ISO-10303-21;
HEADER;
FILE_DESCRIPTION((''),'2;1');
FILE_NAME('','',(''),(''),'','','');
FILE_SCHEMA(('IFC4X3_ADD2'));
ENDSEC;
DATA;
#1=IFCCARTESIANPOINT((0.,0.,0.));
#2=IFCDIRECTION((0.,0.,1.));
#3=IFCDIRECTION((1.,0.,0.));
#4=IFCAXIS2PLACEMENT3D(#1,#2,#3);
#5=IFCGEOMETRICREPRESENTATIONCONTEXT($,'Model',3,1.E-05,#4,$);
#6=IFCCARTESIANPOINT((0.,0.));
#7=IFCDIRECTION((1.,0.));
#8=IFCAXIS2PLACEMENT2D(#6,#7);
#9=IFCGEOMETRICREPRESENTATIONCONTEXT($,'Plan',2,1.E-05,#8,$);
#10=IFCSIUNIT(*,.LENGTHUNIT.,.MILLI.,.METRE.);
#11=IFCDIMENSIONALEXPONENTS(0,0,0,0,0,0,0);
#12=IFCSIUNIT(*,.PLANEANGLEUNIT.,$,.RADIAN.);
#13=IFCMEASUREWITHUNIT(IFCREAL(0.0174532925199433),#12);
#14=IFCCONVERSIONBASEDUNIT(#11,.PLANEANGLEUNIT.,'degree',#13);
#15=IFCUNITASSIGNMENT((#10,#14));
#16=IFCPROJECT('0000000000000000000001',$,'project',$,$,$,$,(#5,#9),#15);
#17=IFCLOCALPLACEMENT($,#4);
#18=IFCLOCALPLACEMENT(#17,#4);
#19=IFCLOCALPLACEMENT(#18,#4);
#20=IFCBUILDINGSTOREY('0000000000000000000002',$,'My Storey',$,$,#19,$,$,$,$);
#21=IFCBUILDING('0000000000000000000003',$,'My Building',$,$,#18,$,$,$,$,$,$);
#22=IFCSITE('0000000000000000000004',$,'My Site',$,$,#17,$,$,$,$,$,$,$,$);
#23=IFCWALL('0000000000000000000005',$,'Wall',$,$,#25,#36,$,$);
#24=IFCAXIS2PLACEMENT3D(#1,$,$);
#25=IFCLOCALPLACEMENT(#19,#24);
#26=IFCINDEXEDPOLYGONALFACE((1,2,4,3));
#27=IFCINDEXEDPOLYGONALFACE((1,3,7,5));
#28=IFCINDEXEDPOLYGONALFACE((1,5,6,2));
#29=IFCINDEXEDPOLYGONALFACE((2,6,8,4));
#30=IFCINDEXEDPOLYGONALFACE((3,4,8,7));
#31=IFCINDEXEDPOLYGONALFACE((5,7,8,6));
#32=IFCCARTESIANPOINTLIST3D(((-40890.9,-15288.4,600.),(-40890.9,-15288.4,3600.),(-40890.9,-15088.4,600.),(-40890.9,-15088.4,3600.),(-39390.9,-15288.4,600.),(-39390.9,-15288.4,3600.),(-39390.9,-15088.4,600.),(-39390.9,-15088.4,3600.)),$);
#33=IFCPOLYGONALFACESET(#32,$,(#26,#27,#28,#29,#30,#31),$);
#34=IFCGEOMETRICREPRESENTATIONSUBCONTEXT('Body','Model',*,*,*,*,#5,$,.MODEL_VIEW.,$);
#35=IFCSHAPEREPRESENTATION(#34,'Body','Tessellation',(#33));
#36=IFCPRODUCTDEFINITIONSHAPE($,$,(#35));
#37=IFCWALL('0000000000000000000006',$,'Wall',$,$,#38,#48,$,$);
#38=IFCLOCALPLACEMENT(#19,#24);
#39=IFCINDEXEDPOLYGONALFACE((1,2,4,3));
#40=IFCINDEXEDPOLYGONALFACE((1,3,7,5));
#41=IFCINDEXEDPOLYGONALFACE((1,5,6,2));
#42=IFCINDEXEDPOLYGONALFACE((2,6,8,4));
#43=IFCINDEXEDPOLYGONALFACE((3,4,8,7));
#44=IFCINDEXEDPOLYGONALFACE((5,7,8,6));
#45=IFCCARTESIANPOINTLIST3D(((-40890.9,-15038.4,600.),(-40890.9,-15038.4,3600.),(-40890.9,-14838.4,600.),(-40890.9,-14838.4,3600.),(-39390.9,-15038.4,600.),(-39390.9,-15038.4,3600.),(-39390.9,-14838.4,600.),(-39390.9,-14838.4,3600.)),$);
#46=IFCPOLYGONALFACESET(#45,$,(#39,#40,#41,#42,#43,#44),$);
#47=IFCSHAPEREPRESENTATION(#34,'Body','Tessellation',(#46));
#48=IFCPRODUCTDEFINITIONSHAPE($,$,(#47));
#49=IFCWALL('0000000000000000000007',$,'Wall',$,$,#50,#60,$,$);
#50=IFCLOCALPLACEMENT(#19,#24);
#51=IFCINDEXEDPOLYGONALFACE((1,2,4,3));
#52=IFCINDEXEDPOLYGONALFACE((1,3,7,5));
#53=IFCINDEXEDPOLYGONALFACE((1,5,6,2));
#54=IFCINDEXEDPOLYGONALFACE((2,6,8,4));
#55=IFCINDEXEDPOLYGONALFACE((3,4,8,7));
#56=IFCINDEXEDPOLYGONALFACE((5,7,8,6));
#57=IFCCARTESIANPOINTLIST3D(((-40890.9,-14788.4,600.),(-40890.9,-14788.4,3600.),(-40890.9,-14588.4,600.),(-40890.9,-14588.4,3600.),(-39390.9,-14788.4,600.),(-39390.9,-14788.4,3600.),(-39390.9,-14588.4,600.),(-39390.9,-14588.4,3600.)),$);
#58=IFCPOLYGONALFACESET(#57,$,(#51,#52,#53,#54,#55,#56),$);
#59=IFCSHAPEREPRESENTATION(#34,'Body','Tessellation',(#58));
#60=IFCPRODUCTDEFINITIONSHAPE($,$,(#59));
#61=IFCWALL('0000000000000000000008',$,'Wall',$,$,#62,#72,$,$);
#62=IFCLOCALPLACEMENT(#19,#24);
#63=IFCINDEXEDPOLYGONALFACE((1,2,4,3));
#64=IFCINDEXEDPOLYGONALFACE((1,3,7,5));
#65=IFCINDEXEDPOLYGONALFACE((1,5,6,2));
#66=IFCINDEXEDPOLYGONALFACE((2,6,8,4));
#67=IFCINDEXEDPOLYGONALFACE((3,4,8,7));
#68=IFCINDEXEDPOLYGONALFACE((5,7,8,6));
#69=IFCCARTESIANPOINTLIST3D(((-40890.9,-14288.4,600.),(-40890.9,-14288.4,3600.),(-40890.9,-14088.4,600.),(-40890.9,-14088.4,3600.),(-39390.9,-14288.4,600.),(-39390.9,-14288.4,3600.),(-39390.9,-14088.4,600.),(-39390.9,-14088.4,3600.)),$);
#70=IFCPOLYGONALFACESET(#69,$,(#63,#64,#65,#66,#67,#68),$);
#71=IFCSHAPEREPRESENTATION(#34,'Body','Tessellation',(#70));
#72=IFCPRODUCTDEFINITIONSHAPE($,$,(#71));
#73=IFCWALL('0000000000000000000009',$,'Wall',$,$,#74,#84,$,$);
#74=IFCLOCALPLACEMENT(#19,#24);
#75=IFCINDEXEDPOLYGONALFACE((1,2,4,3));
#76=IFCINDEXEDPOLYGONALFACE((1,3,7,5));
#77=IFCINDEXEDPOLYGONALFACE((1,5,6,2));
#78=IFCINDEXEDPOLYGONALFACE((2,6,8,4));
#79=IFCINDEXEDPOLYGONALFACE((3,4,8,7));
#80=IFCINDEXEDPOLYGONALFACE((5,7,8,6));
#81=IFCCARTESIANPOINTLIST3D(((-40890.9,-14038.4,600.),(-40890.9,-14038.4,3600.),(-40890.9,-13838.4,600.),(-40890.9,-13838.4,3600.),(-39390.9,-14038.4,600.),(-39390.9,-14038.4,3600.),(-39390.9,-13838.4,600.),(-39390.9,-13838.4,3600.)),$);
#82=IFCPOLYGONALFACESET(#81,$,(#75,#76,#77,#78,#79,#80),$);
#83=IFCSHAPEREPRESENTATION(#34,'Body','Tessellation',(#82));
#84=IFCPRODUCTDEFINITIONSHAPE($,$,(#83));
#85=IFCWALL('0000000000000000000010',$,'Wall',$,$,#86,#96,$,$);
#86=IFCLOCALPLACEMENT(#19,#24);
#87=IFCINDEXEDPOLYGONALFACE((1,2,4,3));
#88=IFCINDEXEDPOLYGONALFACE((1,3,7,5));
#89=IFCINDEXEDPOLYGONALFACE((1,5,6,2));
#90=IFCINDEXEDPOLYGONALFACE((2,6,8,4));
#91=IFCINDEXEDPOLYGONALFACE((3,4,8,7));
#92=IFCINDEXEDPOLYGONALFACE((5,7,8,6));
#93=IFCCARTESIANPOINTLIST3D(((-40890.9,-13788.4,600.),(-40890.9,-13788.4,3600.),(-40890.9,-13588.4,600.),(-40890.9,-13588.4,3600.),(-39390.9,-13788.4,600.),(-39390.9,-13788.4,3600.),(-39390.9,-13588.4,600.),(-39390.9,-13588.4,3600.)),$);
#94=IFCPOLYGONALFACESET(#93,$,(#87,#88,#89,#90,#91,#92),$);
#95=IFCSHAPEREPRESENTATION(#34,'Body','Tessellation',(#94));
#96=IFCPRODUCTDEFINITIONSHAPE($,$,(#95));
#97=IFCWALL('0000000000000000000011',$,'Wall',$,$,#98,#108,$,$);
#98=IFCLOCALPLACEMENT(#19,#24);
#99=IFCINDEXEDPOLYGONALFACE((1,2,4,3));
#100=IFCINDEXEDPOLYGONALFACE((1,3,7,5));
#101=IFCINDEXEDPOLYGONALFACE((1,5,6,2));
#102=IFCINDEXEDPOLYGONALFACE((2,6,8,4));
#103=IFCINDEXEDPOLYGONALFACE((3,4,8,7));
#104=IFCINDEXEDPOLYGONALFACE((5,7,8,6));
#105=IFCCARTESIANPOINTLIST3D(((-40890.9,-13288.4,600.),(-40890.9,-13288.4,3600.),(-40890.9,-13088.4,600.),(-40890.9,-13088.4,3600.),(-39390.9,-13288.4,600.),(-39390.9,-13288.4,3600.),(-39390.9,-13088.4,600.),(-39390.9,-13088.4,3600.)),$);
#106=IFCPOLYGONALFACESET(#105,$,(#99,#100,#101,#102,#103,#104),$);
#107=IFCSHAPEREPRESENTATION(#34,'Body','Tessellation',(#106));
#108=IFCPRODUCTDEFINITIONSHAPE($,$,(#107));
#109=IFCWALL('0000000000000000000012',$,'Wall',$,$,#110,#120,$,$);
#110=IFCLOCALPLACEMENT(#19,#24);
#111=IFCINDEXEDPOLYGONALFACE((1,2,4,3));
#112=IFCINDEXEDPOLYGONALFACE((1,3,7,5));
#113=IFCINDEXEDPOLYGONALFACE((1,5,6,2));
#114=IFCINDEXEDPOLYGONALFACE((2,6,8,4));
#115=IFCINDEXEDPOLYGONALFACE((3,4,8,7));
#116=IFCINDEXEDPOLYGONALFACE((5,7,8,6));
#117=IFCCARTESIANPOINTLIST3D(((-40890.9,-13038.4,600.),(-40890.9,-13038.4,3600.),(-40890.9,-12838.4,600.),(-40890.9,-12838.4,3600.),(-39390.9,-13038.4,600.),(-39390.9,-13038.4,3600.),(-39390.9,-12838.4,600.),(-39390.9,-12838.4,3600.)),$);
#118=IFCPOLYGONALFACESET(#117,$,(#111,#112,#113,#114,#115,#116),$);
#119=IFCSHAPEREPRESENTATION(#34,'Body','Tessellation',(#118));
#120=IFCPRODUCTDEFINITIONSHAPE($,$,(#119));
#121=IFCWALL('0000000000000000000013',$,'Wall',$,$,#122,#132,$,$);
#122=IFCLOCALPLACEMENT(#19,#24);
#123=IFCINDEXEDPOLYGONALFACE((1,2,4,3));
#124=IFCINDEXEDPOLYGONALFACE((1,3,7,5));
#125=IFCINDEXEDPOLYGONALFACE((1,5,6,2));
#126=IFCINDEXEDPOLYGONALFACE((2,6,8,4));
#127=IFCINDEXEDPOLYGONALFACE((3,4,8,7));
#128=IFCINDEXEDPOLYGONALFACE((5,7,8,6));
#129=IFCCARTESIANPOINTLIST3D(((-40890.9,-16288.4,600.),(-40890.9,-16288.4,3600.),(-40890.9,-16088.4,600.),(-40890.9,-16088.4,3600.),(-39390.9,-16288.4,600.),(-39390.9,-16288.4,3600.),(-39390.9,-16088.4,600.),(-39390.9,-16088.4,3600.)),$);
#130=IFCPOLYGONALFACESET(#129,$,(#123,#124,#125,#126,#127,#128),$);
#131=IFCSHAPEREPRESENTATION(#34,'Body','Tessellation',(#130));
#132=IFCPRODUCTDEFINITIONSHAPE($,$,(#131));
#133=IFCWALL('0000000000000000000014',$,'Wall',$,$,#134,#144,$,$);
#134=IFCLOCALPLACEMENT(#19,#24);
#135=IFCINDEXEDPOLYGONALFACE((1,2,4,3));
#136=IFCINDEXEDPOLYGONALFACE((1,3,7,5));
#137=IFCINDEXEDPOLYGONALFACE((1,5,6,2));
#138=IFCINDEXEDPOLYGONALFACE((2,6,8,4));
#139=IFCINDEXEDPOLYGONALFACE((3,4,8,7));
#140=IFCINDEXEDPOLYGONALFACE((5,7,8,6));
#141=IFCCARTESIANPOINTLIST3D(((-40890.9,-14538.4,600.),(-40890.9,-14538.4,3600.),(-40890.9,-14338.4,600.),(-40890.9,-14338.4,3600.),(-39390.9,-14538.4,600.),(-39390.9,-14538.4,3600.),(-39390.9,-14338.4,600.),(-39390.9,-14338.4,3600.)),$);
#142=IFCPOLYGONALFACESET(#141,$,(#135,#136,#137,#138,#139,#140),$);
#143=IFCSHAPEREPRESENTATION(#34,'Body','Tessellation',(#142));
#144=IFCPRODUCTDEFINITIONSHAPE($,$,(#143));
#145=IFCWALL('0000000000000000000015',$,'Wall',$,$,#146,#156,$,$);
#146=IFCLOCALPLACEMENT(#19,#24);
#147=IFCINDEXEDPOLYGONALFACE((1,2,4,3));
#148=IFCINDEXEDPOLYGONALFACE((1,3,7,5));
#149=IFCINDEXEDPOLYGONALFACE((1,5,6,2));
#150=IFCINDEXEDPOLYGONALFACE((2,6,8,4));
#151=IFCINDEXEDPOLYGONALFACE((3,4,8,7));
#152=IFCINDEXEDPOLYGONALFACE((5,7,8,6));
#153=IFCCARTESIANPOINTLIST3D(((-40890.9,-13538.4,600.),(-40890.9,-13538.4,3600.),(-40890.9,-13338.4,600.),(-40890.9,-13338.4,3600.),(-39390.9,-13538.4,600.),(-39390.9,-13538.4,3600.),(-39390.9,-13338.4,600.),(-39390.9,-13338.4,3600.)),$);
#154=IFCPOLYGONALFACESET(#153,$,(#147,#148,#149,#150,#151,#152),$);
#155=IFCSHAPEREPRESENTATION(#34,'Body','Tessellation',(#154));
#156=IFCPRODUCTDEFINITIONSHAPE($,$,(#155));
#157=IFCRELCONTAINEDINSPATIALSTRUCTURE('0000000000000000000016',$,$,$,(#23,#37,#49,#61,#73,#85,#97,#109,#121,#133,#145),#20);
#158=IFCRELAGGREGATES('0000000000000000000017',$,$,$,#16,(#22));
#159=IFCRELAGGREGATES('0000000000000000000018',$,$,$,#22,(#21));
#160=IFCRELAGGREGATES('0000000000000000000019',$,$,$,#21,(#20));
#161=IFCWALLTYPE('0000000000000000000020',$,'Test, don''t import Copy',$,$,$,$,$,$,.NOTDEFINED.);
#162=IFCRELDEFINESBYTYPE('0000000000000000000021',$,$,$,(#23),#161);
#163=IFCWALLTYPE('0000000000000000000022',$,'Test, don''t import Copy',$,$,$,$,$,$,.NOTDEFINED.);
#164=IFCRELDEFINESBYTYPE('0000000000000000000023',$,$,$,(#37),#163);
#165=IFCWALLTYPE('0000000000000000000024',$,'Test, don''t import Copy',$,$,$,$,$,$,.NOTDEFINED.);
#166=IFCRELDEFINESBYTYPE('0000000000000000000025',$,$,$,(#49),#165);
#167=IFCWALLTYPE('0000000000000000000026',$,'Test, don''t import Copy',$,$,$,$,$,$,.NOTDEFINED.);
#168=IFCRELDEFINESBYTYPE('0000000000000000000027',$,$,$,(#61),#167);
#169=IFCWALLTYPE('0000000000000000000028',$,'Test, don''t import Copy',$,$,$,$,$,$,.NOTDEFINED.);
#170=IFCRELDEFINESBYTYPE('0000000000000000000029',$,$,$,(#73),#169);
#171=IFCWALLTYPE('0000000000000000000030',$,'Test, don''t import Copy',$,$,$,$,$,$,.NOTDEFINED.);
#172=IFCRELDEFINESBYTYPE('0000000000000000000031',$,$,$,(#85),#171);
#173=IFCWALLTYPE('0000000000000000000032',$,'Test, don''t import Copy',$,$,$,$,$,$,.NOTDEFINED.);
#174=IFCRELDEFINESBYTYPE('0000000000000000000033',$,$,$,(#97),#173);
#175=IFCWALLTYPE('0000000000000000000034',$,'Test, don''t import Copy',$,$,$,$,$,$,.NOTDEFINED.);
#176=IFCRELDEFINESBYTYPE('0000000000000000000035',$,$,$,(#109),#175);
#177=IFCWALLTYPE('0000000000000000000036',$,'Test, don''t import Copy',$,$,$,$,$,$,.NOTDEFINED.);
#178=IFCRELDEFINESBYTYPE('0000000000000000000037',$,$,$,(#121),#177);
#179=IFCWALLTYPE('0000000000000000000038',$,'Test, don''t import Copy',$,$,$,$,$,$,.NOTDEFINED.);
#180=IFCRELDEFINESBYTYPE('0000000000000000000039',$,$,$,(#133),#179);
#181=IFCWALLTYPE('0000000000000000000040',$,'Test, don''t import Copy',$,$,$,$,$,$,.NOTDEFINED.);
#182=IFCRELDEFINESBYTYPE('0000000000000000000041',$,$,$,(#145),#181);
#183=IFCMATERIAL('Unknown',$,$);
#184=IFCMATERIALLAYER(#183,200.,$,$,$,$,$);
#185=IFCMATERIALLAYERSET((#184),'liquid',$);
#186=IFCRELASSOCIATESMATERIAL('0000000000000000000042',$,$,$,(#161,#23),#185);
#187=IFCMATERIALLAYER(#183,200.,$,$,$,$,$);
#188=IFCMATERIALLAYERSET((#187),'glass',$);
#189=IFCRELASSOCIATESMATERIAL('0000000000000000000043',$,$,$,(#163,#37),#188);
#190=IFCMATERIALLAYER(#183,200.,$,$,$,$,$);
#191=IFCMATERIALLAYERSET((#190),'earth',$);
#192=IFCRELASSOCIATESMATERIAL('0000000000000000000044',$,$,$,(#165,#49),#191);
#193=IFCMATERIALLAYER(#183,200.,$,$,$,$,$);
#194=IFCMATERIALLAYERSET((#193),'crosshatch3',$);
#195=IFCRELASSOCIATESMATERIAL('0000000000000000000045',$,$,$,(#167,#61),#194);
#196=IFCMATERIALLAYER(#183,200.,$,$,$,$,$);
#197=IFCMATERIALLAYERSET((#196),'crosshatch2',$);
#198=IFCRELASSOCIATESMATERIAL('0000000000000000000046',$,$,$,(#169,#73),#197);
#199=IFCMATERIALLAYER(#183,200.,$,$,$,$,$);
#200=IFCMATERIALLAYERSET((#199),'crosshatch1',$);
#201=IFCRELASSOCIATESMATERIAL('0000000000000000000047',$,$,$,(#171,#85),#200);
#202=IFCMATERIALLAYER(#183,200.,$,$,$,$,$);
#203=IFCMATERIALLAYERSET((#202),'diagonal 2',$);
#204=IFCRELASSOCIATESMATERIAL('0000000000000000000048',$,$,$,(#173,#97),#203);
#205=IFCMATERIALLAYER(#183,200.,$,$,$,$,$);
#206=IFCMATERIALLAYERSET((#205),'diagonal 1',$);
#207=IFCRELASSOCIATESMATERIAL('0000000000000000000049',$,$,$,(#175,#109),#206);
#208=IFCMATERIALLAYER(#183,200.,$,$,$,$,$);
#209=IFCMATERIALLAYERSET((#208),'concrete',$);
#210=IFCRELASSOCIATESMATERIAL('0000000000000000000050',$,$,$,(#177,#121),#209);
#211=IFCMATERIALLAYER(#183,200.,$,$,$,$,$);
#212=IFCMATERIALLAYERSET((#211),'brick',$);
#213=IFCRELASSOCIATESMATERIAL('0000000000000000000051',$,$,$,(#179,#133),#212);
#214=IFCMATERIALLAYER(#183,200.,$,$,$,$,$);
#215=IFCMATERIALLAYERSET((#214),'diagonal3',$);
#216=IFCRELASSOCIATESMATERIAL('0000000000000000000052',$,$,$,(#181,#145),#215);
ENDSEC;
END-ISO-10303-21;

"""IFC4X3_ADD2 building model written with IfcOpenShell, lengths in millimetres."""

from ifc_helpers import new_model, entity, si_unit, converted_unit, frame, origin_with_axes, origin_2d_with_axis, place, context, subcontext, project, spatial, indexed_curve, outline, extrude, material, layer, layer_set, layer_usage, type_object, element, save


model = new_model("IFC4X3_ADD2")

# Units and contexts
model_context = context("Model", 3, precision=1e-05, world=origin_with_axes())
plan_context = context("Plan", 2, precision=1e-05, world=origin_2d_with_axis())
body_context = subcontext(model_context, "Body", "Model", "MODEL_VIEW")
ifc_project = project(units=[si_unit("LENGTHUNIT", "METRE", prefix="MILLI"), converted_unit("PLANEANGLEUNIT", "degree", entity("IfcReal", 0.0174532925199433), si_unit("PLANEANGLEUNIT", "RADIAN"), dimensions=[0, 0, 0, 0, 0, 0, 0])], contexts=[model_context, plan_context])

# Site, building, storey
site_placement = place(None, origin_with_axes())
site = spatial("IfcSite", under=ifc_project, at=site_placement, Name="My Site")
building_placement = place(site_placement, origin_with_axes())
building = spatial("IfcBuilding", under=site, at=building_placement, Name="My Building")
storey_placement = place(building_placement, origin_with_axes())
storey = spatial("IfcBuildingStorey", under=building, at=storey_placement, Name="My Storey")

# Walls
ifc_material_1 = material(Name="Unknown")
ifc_layer_1 = layer(ifc_material_1, 200.0)
ifc_layer_set_1 = layer_set([ifc_layer_1], Name="liquid")
ifc_layer_usage_1 = layer_usage(ifc_layer_set_1, "AXIS2", "POSITIVE", 0.0)
wall_type_1 = type_object("IfcWallType", Name="Test, don't import Copy", PredefinedType="NOTDEFINED", material=ifc_layer_set_1)
wall_1_placement = place(storey_placement, frame((-40890.9, -15288.4, 600.0), z_axis=(0.0, 0.0, 1.0), x_axis=(1.0, 0.0, 0.0)))
element("IfcWall", 1, at=wall_1_placement, inside=storey, type_object=wall_type_1, material=ifc_layer_usage_1, Name="Wall", context=body_context, shape_type="SweptSolid", body=[
    extrude(outline(indexed_curve([(0.0, 0.0), (0.0, 200.0), (1500.0, 200.0), (1500.0, 0.0), (0.0, 0.0)], self_intersect=False)), origin_with_axes(), (0.0, 0.0, 1.0), 3000.0),
])
ifc_layer_2 = layer(ifc_material_1, 200.0)
ifc_layer_set_2 = layer_set([ifc_layer_2], Name="glass")
ifc_layer_usage_2 = layer_usage(ifc_layer_set_2, "AXIS2", "POSITIVE", 0.0)
wall_type_2 = type_object("IfcWallType", Name="Test, don't import Copy", PredefinedType="NOTDEFINED", material=ifc_layer_set_2)
wall_2_placement = place(storey_placement, frame((-40890.9, -15038.4, 600.0), z_axis=(0.0, 0.0, 1.0), x_axis=(1.0, 0.0, 0.0)))
element("IfcWall", 2, at=wall_2_placement, inside=storey, type_object=wall_type_2, material=ifc_layer_usage_2, Name="Wall", context=body_context, shape_type="SweptSolid", body=[
    extrude(outline(indexed_curve([(0.0, 0.0), (0.0, 200.0), (1500.0, 200.0), (1500.0, 0.0), (0.0, 0.0)], self_intersect=False)), origin_with_axes(), (0.0, 0.0, 1.0), 3000.0),
])
ifc_layer_3 = layer(ifc_material_1, 200.0)
ifc_layer_set_3 = layer_set([ifc_layer_3], Name="earth")
ifc_layer_usage_3 = layer_usage(ifc_layer_set_3, "AXIS2", "POSITIVE", 0.0)
wall_type_3 = type_object("IfcWallType", Name="Test, don't import Copy", PredefinedType="NOTDEFINED", material=ifc_layer_set_3)
wall_3_placement = place(storey_placement, frame((-40890.9, -14788.4, 600.0), z_axis=(0.0, 0.0, 1.0), x_axis=(1.0, 0.0, 0.0)))
element("IfcWall", 3, at=wall_3_placement, inside=storey, type_object=wall_type_3, material=ifc_layer_usage_3, Name="Wall", context=body_context, shape_type="SweptSolid", body=[
    extrude(outline(indexed_curve([(0.0, 0.0), (0.0, 200.0), (1500.0, 200.0), (1500.0, 0.0), (0.0, 0.0)], self_intersect=False)), origin_with_axes(), (0.0, 0.0, 1.0), 3000.0),
])
ifc_layer_4 = layer(ifc_material_1, 200.0)
ifc_layer_set_4 = layer_set([ifc_layer_4], Name="crosshatch3")
ifc_layer_usage_4 = layer_usage(ifc_layer_set_4, "AXIS2", "POSITIVE", 0.0)
wall_type_4 = type_object("IfcWallType", Name="Test, don't import Copy", PredefinedType="NOTDEFINED", material=ifc_layer_set_4)
wall_4_placement = place(storey_placement, frame((-40890.9, -14288.4, 600.0), z_axis=(0.0, 0.0, 1.0), x_axis=(1.0, 0.0, 0.0)))
element("IfcWall", 4, at=wall_4_placement, inside=storey, type_object=wall_type_4, material=ifc_layer_usage_4, Name="Wall", context=body_context, shape_type="SweptSolid", body=[
    extrude(outline(indexed_curve([(0.0, 0.0), (0.0, 200.0), (1500.0, 200.0), (1500.0, 0.0), (0.0, 0.0)], self_intersect=False)), origin_with_axes(), (0.0, 0.0, 1.0), 3000.0),
])
ifc_layer_5 = layer(ifc_material_1, 200.0)
ifc_layer_set_5 = layer_set([ifc_layer_5], Name="crosshatch2")
ifc_layer_usage_5 = layer_usage(ifc_layer_set_5, "AXIS2", "POSITIVE", 0.0)
wall_type_5 = type_object("IfcWallType", Name="Test, don't import Copy", PredefinedType="NOTDEFINED", material=ifc_layer_set_5)
wall_5_placement = place(storey_placement, frame((-40890.9, -14038.4, 600.0), z_axis=(0.0, 0.0, 1.0), x_axis=(1.0, 0.0, 0.0)))
element("IfcWall", 5, at=wall_5_placement, inside=storey, type_object=wall_type_5, material=ifc_layer_usage_5, Name="Wall", context=body_context, shape_type="SweptSolid", body=[
    extrude(outline(indexed_curve([(0.0, 0.0), (0.0, 200.0), (1500.0, 200.0), (1500.0, 0.0), (0.0, 0.0)], self_intersect=False)), origin_with_axes(), (0.0, 0.0, 1.0), 3000.0),
])
ifc_layer_6 = layer(ifc_material_1, 200.0)
ifc_layer_set_6 = layer_set([ifc_layer_6], Name="crosshatch1")
ifc_layer_usage_6 = layer_usage(ifc_layer_set_6, "AXIS2", "POSITIVE", 0.0)
wall_type_6 = type_object("IfcWallType", Name="Test, don't import Copy", PredefinedType="NOTDEFINED", material=ifc_layer_set_6)
wall_6_placement = place(storey_placement, frame((-40890.9, -13788.4, 600.0), z_axis=(0.0, 0.0, 1.0), x_axis=(1.0, 0.0, 0.0)))
element("IfcWall", 6, at=wall_6_placement, inside=storey, type_object=wall_type_6, material=ifc_layer_usage_6, Name="Wall", context=body_context, shape_type="SweptSolid", body=[
    extrude(outline(indexed_curve([(0.0, 0.0), (0.0, 200.0), (1500.0, 200.0), (1500.0, 0.0), (0.0, 0.0)], self_intersect=False)), origin_with_axes(), (0.0, 0.0, 1.0), 3000.0),
])
ifc_layer_7 = layer(ifc_material_1, 200.0)
ifc_layer_set_7 = layer_set([ifc_layer_7], Name="diagonal 2")
ifc_layer_usage_7 = layer_usage(ifc_layer_set_7, "AXIS2", "POSITIVE", 0.0)
wall_type_7 = type_object("IfcWallType", Name="Test, don't import Copy", PredefinedType="NOTDEFINED", material=ifc_layer_set_7)
wall_7_placement = place(storey_placement, frame((-40890.9, -13288.4, 600.0), z_axis=(0.0, 0.0, 1.0), x_axis=(1.0, 0.0, 0.0)))
element("IfcWall", 7, at=wall_7_placement, inside=storey, type_object=wall_type_7, material=ifc_layer_usage_7, Name="Wall", context=body_context, shape_type="SweptSolid", body=[
    extrude(outline(indexed_curve([(0.0, 0.0), (0.0, 200.0), (1500.0, 200.0), (1500.0, 0.0), (0.0, 0.0)], self_intersect=False)), origin_with_axes(), (0.0, 0.0, 1.0), 3000.0),
])
ifc_layer_8 = layer(ifc_material_1, 200.0)
ifc_layer_set_8 = layer_set([ifc_layer_8], Name="diagonal 1")
ifc_layer_usage_8 = layer_usage(ifc_layer_set_8, "AXIS2", "POSITIVE", 0.0)
wall_type_8 = type_object("IfcWallType", Name="Test, don't import Copy", PredefinedType="NOTDEFINED", material=ifc_layer_set_8)
wall_8_placement = place(storey_placement, frame((-40890.9, -13038.4, 600.0), z_axis=(0.0, 0.0, 1.0), x_axis=(1.0, 0.0, 0.0)))
element("IfcWall", 8, at=wall_8_placement, inside=storey, type_object=wall_type_8, material=ifc_layer_usage_8, Name="Wall", context=body_context, shape_type="SweptSolid", body=[
    extrude(outline(indexed_curve([(0.0, 0.0), (0.0, 200.0), (1500.0, 200.0), (1500.0, 0.0), (0.0, 0.0)], self_intersect=False)), origin_with_axes(), (0.0, 0.0, 1.0), 3000.0),
])
ifc_layer_9 = layer(ifc_material_1, 200.0)
ifc_layer_set_9 = layer_set([ifc_layer_9], Name="concrete")
ifc_layer_usage_9 = layer_usage(ifc_layer_set_9, "AXIS2", "POSITIVE", 0.0)
wall_type_9 = type_object("IfcWallType", Name="Test, don't import Copy", PredefinedType="NOTDEFINED", material=ifc_layer_set_9)
wall_9_placement = place(storey_placement, frame((-40890.9, -16288.4, 600.0), z_axis=(0.0, 0.0, 1.0), x_axis=(1.0, 0.0, 0.0)))
element("IfcWall", 9, at=wall_9_placement, inside=storey, type_object=wall_type_9, material=ifc_layer_usage_9, Name="Wall", context=body_context, shape_type="SweptSolid", body=[
    extrude(outline(indexed_curve([(0.0, 0.0), (0.0, 200.0), (1500.0, 200.0), (1500.0, 0.0), (0.0, 0.0)], self_intersect=False)), origin_with_axes(), (0.0, 0.0, 1.0), 3000.0),
])
ifc_layer_10 = layer(ifc_material_1, 200.0)
ifc_layer_set_10 = layer_set([ifc_layer_10], Name="brick")
ifc_layer_usage_10 = layer_usage(ifc_layer_set_10, "AXIS2", "POSITIVE", 0.0)
wall_type_10 = type_object("IfcWallType", Name="Test, don't import Copy", PredefinedType="NOTDEFINED", material=ifc_layer_set_10)
wall_10_placement = place(storey_placement, frame((-40890.9, -14538.4, 600.0), z_axis=(0.0, 0.0, 1.0), x_axis=(1.0, 0.0, 0.0)))
element("IfcWall", 10, at=wall_10_placement, inside=storey, type_object=wall_type_10, material=ifc_layer_usage_10, Name="Wall", context=body_context, shape_type="SweptSolid", body=[
    extrude(outline(indexed_curve([(0.0, 0.0), (0.0, 200.0), (1500.0, 200.0), (1500.0, 0.0), (0.0, 0.0)], self_intersect=False)), origin_with_axes(), (0.0, 0.0, 1.0), 3000.0),
])
ifc_layer_11 = layer(ifc_material_1, 200.0)
ifc_layer_set_11 = layer_set([ifc_layer_11], Name="diagonal3")
ifc_layer_usage_11 = layer_usage(ifc_layer_set_11, "AXIS2", "POSITIVE", 0.0)
wall_type_11 = type_object("IfcWallType", Name="Test, don't import Copy", PredefinedType="NOTDEFINED", material=ifc_layer_set_11)
wall_11_placement = place(storey_placement, frame((-40890.9, -13538.4, 600.0), z_axis=(0.0, 0.0, 1.0), x_axis=(1.0, 0.0, 0.0)))
element("IfcWall", 11, at=wall_11_placement, inside=storey, type_object=wall_type_11, material=ifc_layer_usage_11, Name="Wall", context=body_context, shape_type="SweptSolid", body=[
    extrude(outline(indexed_curve([(0.0, 0.0), (0.0, 200.0), (1500.0, 200.0), (1500.0, 0.0), (0.0, 0.0)], self_intersect=False)), origin_with_axes(), (0.0, 0.0, 1.0), 3000.0),
])

save(model, "model.ifc")
